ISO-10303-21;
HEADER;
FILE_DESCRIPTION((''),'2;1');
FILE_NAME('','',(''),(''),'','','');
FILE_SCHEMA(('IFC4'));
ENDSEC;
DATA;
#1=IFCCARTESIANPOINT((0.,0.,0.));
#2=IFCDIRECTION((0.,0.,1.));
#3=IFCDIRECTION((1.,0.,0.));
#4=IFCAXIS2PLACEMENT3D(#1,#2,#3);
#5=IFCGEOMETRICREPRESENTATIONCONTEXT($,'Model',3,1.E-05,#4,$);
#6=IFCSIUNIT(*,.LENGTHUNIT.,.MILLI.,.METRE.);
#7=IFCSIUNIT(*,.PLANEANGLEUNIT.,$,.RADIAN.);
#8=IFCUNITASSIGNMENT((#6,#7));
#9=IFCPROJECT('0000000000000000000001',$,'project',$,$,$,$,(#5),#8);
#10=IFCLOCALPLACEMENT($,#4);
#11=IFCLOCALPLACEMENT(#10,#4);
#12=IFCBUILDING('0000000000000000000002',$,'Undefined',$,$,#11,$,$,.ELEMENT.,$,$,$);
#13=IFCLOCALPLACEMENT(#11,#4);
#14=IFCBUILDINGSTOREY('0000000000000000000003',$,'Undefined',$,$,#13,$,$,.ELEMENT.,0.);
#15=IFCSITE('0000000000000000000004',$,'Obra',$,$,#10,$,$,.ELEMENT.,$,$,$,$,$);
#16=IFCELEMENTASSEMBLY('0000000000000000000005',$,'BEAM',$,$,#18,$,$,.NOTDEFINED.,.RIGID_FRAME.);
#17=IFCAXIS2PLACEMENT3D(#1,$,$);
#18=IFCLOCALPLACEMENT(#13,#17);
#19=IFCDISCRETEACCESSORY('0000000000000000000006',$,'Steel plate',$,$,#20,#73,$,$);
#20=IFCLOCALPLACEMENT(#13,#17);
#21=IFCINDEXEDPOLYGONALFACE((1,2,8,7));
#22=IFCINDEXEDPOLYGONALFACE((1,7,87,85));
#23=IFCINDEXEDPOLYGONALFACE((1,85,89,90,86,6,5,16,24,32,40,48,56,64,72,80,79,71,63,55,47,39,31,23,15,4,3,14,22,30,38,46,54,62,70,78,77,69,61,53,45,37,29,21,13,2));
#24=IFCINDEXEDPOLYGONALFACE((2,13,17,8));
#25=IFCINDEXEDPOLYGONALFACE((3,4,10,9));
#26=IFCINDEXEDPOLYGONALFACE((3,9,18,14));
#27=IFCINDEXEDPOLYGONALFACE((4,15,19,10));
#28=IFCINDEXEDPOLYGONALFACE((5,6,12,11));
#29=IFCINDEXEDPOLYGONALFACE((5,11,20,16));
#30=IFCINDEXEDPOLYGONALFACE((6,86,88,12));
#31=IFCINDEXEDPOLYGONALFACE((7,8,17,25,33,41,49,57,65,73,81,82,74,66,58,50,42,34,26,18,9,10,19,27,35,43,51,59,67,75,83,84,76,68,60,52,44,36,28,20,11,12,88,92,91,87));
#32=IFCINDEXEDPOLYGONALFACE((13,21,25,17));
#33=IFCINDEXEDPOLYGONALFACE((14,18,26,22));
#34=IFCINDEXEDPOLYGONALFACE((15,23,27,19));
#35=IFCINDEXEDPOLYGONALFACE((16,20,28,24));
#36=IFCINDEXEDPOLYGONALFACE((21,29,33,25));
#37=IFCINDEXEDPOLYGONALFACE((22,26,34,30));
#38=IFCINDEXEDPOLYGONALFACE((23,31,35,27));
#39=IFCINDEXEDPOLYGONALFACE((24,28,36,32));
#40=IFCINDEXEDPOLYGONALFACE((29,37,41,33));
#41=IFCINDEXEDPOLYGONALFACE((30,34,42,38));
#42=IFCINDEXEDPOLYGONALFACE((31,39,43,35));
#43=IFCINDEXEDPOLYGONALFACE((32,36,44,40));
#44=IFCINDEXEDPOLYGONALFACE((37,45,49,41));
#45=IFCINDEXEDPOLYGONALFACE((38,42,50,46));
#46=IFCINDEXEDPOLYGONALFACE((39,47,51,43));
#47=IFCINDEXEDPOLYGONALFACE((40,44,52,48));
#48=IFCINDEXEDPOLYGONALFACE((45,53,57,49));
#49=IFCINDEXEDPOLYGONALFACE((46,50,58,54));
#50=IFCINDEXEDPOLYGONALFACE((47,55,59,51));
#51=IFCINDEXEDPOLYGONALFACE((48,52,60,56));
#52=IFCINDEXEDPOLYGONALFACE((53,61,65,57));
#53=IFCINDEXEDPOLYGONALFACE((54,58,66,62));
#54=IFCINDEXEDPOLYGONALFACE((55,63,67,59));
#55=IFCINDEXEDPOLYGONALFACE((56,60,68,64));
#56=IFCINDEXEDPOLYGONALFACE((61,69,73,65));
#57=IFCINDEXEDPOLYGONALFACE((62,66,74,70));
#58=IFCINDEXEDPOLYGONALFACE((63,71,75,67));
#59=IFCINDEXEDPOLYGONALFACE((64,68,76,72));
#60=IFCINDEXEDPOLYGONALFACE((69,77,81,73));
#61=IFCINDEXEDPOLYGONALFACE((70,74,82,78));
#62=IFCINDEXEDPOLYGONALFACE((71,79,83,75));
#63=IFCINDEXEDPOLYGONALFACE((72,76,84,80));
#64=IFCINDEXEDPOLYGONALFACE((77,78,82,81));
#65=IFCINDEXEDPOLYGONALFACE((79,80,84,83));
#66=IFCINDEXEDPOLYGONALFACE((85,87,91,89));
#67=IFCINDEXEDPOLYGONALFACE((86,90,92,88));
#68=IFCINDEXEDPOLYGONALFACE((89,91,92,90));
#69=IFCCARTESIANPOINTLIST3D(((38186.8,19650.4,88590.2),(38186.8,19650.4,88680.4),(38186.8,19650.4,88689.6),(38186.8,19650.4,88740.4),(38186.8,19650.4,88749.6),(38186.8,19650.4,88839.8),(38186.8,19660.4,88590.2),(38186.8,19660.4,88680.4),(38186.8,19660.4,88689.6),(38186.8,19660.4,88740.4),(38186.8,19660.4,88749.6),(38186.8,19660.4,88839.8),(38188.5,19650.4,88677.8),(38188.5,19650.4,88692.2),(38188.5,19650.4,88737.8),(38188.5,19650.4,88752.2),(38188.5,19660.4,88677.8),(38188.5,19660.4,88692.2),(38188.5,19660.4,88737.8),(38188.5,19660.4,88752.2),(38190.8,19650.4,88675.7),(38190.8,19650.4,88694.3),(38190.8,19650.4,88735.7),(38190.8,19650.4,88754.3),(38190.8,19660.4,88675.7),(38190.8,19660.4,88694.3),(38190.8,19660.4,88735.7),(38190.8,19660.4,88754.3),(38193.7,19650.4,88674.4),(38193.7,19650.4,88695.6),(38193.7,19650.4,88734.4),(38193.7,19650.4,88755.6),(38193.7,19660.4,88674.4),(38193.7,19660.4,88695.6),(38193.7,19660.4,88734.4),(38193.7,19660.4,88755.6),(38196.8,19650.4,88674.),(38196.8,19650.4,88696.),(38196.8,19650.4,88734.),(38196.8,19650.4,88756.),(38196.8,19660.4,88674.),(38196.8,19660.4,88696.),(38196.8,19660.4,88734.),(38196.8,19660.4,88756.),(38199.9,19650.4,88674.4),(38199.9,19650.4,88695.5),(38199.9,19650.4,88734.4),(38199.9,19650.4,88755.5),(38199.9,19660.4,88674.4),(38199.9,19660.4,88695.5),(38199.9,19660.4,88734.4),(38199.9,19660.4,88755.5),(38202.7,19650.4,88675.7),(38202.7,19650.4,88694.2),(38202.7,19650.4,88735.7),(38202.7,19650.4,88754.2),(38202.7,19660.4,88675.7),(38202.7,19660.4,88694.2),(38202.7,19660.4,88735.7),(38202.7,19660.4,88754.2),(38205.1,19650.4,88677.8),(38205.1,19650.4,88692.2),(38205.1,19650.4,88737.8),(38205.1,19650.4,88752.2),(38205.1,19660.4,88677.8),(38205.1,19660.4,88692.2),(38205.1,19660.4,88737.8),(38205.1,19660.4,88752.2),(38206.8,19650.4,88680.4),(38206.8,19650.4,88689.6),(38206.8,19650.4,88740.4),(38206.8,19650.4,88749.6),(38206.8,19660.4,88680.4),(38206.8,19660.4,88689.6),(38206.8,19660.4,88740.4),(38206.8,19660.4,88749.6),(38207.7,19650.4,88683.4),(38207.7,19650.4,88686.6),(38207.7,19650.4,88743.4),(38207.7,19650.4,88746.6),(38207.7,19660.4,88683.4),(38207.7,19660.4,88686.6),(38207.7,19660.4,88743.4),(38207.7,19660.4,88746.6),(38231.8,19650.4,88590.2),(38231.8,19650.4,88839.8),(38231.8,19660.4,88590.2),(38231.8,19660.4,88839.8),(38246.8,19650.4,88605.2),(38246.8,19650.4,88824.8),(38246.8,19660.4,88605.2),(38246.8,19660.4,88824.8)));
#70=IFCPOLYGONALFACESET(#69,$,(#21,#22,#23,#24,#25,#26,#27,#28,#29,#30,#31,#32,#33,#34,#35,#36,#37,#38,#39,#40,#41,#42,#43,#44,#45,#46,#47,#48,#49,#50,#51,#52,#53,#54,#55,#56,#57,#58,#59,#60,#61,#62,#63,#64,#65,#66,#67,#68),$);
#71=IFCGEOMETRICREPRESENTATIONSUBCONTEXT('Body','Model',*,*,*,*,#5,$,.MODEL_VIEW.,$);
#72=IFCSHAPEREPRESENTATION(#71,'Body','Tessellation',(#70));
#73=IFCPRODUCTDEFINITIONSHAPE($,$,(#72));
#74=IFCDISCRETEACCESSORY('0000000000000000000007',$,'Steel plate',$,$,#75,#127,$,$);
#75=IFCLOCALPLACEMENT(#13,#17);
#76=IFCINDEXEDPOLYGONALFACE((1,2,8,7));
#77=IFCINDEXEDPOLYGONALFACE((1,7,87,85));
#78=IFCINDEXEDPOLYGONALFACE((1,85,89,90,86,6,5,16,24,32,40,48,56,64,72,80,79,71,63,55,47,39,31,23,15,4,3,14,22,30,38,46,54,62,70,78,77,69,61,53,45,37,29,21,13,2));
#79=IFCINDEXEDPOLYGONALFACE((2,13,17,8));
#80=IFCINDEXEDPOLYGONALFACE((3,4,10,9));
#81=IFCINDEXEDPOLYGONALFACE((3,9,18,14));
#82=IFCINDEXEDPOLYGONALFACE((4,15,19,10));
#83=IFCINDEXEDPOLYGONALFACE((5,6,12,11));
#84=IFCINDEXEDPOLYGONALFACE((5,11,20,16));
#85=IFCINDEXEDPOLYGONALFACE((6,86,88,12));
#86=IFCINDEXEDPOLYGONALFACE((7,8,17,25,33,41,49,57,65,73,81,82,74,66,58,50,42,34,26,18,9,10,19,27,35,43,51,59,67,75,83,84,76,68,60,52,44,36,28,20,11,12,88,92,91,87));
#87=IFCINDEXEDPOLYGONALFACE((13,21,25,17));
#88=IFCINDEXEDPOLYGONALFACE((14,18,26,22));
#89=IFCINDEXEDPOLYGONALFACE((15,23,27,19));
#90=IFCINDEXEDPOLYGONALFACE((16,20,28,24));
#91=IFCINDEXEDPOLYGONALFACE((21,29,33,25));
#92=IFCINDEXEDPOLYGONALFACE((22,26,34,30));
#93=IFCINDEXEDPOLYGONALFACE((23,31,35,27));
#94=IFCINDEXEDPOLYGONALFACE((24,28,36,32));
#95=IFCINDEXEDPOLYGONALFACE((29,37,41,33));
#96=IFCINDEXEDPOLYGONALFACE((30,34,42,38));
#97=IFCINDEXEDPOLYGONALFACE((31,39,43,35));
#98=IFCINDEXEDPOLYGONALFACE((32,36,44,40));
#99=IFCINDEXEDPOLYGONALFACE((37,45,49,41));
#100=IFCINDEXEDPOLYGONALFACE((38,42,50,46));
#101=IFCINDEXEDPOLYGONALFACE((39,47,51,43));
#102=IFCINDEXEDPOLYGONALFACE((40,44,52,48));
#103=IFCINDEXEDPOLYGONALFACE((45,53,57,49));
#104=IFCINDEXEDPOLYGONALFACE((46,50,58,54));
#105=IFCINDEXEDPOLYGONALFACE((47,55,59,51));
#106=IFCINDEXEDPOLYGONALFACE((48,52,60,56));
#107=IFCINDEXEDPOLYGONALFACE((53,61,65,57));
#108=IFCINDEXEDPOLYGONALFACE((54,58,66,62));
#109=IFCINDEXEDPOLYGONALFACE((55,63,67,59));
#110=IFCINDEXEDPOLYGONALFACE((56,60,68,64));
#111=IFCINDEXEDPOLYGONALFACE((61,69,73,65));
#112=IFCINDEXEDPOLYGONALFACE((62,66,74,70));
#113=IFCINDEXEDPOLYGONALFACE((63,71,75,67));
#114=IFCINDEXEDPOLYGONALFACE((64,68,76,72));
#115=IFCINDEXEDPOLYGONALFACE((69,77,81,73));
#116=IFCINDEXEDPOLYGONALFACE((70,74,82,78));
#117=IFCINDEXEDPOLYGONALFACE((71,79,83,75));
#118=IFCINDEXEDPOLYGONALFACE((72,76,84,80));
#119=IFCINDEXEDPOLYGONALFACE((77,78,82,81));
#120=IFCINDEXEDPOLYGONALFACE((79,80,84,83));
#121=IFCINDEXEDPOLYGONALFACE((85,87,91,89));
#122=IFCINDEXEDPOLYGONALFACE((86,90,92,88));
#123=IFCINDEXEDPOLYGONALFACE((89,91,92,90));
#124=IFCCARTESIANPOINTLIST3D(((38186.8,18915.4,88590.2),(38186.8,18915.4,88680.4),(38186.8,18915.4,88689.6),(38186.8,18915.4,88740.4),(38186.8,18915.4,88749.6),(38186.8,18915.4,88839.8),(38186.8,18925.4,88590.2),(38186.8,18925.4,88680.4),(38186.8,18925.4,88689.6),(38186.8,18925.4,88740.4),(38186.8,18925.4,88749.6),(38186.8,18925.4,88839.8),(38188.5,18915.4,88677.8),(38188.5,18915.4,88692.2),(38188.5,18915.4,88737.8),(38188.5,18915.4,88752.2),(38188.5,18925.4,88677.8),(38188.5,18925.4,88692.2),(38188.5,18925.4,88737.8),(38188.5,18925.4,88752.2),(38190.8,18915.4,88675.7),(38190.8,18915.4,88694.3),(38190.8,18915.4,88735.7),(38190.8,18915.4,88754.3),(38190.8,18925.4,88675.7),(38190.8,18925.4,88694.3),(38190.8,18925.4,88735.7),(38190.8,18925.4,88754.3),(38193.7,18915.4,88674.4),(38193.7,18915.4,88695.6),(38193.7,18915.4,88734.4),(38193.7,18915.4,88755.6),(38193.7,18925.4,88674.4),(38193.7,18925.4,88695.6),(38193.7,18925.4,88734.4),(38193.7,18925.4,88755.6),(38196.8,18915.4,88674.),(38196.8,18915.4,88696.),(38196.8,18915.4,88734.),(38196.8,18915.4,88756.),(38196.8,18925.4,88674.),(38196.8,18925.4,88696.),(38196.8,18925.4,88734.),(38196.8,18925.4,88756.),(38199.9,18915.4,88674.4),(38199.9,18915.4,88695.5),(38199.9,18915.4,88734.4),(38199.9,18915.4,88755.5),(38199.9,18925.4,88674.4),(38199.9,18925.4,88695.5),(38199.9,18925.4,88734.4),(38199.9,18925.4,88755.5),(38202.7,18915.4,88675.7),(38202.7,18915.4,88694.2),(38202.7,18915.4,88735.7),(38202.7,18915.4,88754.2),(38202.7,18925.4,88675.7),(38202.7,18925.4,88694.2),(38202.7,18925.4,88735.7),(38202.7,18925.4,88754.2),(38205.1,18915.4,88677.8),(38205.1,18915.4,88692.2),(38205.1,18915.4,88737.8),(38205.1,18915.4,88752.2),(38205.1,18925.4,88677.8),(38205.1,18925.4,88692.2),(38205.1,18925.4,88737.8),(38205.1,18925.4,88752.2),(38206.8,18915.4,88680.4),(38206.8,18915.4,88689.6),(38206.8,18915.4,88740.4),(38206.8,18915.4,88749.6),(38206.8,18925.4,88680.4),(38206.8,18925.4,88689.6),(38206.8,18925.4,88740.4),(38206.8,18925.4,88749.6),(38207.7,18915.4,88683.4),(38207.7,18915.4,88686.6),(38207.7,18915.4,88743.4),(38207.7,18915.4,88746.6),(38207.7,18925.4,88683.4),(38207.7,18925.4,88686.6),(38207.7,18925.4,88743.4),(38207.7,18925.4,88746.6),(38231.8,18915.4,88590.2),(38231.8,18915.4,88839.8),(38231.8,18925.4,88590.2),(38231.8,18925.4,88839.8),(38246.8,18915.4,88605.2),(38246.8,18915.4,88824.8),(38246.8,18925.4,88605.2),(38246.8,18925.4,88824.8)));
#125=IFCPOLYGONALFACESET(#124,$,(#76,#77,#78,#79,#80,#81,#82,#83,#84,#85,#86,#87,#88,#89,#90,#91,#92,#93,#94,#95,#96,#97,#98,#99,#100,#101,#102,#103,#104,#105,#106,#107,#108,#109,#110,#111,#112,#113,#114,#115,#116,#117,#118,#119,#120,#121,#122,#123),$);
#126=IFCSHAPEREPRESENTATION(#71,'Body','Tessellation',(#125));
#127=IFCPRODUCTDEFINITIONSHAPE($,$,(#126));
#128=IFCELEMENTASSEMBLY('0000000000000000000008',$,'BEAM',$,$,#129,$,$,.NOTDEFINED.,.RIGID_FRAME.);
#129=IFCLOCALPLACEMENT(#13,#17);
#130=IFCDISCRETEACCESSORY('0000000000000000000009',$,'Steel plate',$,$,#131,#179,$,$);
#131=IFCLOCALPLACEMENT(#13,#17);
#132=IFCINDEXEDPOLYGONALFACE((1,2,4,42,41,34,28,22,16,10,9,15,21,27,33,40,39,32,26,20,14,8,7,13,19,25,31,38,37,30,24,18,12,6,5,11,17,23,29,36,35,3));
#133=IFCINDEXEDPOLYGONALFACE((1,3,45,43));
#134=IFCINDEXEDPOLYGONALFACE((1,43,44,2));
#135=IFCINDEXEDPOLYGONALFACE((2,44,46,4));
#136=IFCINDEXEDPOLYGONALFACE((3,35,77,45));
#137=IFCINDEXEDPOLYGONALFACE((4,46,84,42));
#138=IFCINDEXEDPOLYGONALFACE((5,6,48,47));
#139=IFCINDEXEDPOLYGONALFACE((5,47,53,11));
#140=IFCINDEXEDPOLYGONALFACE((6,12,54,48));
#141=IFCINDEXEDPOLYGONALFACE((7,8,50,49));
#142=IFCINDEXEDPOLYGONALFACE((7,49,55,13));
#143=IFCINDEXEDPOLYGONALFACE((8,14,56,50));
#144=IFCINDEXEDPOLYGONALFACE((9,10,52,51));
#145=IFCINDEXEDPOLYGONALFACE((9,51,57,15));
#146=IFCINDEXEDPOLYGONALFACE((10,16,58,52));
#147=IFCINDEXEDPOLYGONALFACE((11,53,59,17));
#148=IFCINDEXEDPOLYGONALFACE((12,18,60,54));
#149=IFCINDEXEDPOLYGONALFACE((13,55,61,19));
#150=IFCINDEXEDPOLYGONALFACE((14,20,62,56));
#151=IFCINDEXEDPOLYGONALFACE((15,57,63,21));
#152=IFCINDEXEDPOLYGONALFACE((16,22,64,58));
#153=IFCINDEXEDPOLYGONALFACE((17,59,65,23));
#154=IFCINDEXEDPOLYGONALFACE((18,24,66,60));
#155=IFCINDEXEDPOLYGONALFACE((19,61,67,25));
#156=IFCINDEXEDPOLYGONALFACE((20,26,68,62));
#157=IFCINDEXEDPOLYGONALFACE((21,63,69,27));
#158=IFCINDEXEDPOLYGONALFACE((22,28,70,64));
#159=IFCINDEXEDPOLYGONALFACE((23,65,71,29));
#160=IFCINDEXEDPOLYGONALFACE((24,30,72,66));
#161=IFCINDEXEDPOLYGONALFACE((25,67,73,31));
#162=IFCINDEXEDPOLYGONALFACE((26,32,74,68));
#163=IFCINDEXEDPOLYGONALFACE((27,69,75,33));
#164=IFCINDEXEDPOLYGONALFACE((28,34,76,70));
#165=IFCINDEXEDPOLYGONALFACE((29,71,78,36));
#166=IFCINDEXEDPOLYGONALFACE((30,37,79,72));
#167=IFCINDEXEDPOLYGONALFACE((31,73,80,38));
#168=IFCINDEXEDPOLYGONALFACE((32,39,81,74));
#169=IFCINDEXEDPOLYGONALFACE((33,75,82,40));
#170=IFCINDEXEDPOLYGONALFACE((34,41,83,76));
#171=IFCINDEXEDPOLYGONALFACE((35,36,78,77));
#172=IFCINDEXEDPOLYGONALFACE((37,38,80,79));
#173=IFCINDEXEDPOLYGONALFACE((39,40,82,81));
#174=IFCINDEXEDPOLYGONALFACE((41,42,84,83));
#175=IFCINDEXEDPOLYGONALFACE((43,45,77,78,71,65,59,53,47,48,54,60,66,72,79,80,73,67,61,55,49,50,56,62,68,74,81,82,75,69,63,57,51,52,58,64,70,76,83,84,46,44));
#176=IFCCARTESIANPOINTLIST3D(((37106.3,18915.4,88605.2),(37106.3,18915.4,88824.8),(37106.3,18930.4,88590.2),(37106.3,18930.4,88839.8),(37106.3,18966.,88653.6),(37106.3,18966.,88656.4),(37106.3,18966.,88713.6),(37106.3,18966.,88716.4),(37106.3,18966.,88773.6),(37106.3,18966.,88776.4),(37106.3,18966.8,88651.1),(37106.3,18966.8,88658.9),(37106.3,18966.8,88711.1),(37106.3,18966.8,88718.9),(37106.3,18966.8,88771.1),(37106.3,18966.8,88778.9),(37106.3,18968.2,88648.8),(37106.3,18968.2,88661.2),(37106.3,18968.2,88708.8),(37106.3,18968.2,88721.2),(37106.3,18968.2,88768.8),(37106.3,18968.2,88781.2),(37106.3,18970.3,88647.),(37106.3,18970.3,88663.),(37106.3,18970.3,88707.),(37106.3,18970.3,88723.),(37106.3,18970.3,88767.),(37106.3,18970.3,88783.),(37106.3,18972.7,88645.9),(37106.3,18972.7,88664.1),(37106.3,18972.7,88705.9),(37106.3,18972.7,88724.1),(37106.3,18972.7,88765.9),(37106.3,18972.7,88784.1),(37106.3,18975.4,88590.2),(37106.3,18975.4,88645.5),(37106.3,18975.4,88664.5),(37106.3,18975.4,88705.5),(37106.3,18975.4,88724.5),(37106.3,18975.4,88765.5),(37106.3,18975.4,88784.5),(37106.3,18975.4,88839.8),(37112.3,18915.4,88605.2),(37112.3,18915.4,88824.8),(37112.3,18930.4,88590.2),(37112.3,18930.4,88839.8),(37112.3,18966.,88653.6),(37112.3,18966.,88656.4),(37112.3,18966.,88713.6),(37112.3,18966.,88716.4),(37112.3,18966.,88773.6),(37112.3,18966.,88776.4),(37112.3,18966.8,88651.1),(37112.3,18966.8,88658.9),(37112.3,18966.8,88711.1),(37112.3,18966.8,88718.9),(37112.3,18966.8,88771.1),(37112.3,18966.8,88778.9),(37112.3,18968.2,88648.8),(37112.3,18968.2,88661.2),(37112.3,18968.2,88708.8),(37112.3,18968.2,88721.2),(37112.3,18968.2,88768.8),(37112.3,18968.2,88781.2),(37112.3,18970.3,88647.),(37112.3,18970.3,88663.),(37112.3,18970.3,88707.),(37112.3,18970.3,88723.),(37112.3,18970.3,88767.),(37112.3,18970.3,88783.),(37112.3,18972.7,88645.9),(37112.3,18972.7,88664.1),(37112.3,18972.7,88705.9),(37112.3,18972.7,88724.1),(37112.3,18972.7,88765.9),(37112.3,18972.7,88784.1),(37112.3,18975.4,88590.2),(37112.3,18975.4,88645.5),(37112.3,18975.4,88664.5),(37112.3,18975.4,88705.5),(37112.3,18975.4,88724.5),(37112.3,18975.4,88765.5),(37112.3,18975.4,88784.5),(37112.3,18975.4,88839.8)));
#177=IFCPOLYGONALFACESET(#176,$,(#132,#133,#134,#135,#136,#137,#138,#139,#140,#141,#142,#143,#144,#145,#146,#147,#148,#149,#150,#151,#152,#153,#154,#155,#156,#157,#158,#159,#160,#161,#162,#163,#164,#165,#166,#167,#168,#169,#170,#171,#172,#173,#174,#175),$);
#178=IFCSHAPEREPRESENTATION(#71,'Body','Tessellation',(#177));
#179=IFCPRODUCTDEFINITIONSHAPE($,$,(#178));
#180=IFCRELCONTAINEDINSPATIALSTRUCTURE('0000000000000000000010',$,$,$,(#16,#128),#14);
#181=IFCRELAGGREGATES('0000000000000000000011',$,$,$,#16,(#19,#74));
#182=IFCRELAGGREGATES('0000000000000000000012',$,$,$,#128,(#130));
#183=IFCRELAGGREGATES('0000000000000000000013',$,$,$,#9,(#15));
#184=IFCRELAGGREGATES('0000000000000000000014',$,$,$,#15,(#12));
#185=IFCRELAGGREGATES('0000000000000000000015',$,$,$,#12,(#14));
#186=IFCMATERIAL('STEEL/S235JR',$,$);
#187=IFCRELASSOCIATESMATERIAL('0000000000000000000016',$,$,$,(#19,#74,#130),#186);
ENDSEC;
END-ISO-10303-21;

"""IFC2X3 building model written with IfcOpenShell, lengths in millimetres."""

from ifc_helpers import new_model, si_unit, frame, origin_with_axes, origin_2d_with_axis, place, context, subcontext, project, spatial, polyline, circle, outline, extrude, source, transform, mapped, material, element, aggregate, save


model = new_model("IFC2X3")

# Units and contexts
model_context = context("Model", 3, precision=1e-05, world=origin_with_axes())
body_context = subcontext(model_context, "Body", "Model", "MODEL_VIEW")
ifc_project = project(units=[si_unit("LENGTHUNIT", "METRE", prefix="MILLI"), si_unit("PLANEANGLEUNIT", "RADIAN")], contexts=[model_context])

# Site, building, storey
site_placement = place(None, origin_with_axes())
site = spatial("IfcSite", under=ifc_project, at=site_placement, Name="Obra", CompositionType="ELEMENT")
building_placement = place(site_placement, origin_with_axes())
building = spatial("IfcBuilding", under=site, at=building_placement, Name="Undefined", CompositionType="ELEMENT")
storey_placement = place(building_placement, origin_with_axes())
storey = spatial("IfcBuildingStorey", under=building, at=storey_placement, Name="Undefined", CompositionType="ELEMENT", Elevation=0.0)

# Element assembly
ifc_material = material(Name="STEEL/S235JR")
assembly_1_placement = place(storey_placement, origin_with_axes())
assembly_1 = element("IfcElementAssembly", 1, at=assembly_1_placement, inside=storey, Name="BEAM", AssemblyPlace="NOTDEFINED", PredefinedType="RIGID_FRAME")

# Discrete accessories, openings
discrete_accessory_1_placement = place(assembly_1_placement, frame((38186.8, 19655.4, 88590.2), z_axis=(0.0, -1.0, 0.0), x_axis=(1.0, 0.0, 0.0)))
discrete_accessory_1 = element("IfcDiscreteAccessory", 2, at=discrete_accessory_1_placement, material=ifc_material, Name="Steel plate", context=body_context, shape_type="SweptSolid", body=[
    extrude(outline(polyline([(0.0, 0.0), (45.0, 0.0), (60.0, 15.0), (60.0, 234.6), (45.0, 249.6), (0.0, 249.6), (0.0, 0.0)])), frame((0.0, 0.0, -5.0), z_axis=(0.0, 0.0, 1.0), x_axis=(1.0, 0.0, 0.0)), (0.0, 0.0, 1.0), 10.0),
])
shared_shape_1 = source(origin_with_axes(), body_context, "Body", "SweptSolid", [
    extrude(circle(Radius=11.0, at=origin_2d_with_axis()), frame((0.0, -13.4, 0.0), z_axis=(0.0, 1.0, 0.0), x_axis=(1.0, 0.0, 0.0)), (0.0, 0.0, 1.0), 10.2),
])
opening_1_placement = place(assembly_1_placement, frame((38236.8, 19647.1, 88850.0), z_axis=(-1.0, 0.0, 0.0), x_axis=(0.0, 0.0, -1.0)))
element("IfcOpeningElement", 3, at=opening_1_placement, cuts=discrete_accessory_1, ObjectType="Opening", context=body_context, shape_type="MappedRepresentation", body=[
    mapped(shared_shape_1, transform((105.0, 0.0, 40.0))),
    mapped(shared_shape_1, transform((165.0, 0.0, 40.0))),
])
discrete_accessory_2_placement = place(assembly_1_placement, frame((38186.8, 18920.4, 88590.2), z_axis=(0.0, -1.0, 0.0), x_axis=(1.0, 0.0, 0.0)))
discrete_accessory_2 = element("IfcDiscreteAccessory", 4, at=discrete_accessory_2_placement, material=ifc_material, Name="Steel plate", context=body_context, shape_type="SweptSolid", body=[
    extrude(outline(polyline([(0.0, 0.0), (45.0, 0.0), (60.0, 15.0), (60.0, 234.6), (45.0, 249.6), (0.0, 249.6), (0.0, 0.0)])), frame((0.0, 0.0, -5.0), z_axis=(0.0, 0.0, 1.0), x_axis=(1.0, 0.0, 0.0)), (0.0, 0.0, 1.0), 10.0),
])
opening_2_placement = place(assembly_1_placement, frame((38236.8, 18912.1, 88850.0), z_axis=(-1.0, 0.0, 0.0), x_axis=(0.0, 0.0, -1.0)))
element("IfcOpeningElement", 5, at=opening_2_placement, cuts=discrete_accessory_2, ObjectType="Opening", context=body_context, shape_type="MappedRepresentation", body=[
    mapped(shared_shape_1, transform((105.0, 0.0, 40.0))),
    mapped(shared_shape_1, transform((165.0, 0.0, 40.0))),
])
aggregate(assembly_1, [discrete_accessory_1, discrete_accessory_2])

# Element assembly, discrete accessory, opening
assembly_2_placement = place(storey_placement, origin_with_axes())
assembly_2 = element("IfcElementAssembly", 6, at=assembly_2_placement, inside=storey, Name="BEAM", AssemblyPlace="NOTDEFINED", PredefinedType="RIGID_FRAME")
discrete_accessory_3_placement = place(assembly_2_placement, frame((37109.3, 18975.4, 88590.2), z_axis=(-1.0, 0.0, 0.0), x_axis=(0.0, -1.0, 0.0)))
discrete_accessory_3 = element("IfcDiscreteAccessory", 7, at=discrete_accessory_3_placement, material=ifc_material, Name="Steel plate", context=body_context, shape_type="SweptSolid", body=[
    extrude(outline(polyline([(0.0, 0.0), (45.0, 0.0), (60.0, 15.0), (60.0, 234.6), (45.0, 249.6), (0.0, 249.6), (0.0, 0.0)])), frame((0.0, 0.0, -3.0), z_axis=(0.0, 0.0, 1.0), x_axis=(1.0, 0.0, 0.0)), (0.0, 0.0, 1.0), 6.0),
])
shared_shape_2 = source(origin_with_axes(), body_context, "Body", "SweptSolid", [
    extrude(circle(Radius=9.5, at=origin_2d_with_axis()), frame((0.0, -9.4, 0.0), z_axis=(0.0, 1.0, 0.0), x_axis=(1.0, 0.0, 0.0)), (0.0, 0.0, 1.0), 6.2),
])
opening_3_placement = place(assembly_2_placement, frame((37103.0, 18925.4, 88850.0), z_axis=(0.0, 1.0, 0.0), x_axis=(0.0, 0.0, -1.0)))
element("IfcOpeningElement", 8, at=opening_3_placement, cuts=discrete_accessory_3, ObjectType="Opening", context=body_context, shape_type="MappedRepresentation", body=[
    mapped(shared_shape_2, transform((75.0, 0.0, 50.0))),
    mapped(shared_shape_2, transform((135.0, 0.0, 50.0))),
    mapped(shared_shape_2, transform((195.0, 0.0, 50.0))),
])
aggregate(assembly_2, [discrete_accessory_3])

save(model, "model.ifc")
